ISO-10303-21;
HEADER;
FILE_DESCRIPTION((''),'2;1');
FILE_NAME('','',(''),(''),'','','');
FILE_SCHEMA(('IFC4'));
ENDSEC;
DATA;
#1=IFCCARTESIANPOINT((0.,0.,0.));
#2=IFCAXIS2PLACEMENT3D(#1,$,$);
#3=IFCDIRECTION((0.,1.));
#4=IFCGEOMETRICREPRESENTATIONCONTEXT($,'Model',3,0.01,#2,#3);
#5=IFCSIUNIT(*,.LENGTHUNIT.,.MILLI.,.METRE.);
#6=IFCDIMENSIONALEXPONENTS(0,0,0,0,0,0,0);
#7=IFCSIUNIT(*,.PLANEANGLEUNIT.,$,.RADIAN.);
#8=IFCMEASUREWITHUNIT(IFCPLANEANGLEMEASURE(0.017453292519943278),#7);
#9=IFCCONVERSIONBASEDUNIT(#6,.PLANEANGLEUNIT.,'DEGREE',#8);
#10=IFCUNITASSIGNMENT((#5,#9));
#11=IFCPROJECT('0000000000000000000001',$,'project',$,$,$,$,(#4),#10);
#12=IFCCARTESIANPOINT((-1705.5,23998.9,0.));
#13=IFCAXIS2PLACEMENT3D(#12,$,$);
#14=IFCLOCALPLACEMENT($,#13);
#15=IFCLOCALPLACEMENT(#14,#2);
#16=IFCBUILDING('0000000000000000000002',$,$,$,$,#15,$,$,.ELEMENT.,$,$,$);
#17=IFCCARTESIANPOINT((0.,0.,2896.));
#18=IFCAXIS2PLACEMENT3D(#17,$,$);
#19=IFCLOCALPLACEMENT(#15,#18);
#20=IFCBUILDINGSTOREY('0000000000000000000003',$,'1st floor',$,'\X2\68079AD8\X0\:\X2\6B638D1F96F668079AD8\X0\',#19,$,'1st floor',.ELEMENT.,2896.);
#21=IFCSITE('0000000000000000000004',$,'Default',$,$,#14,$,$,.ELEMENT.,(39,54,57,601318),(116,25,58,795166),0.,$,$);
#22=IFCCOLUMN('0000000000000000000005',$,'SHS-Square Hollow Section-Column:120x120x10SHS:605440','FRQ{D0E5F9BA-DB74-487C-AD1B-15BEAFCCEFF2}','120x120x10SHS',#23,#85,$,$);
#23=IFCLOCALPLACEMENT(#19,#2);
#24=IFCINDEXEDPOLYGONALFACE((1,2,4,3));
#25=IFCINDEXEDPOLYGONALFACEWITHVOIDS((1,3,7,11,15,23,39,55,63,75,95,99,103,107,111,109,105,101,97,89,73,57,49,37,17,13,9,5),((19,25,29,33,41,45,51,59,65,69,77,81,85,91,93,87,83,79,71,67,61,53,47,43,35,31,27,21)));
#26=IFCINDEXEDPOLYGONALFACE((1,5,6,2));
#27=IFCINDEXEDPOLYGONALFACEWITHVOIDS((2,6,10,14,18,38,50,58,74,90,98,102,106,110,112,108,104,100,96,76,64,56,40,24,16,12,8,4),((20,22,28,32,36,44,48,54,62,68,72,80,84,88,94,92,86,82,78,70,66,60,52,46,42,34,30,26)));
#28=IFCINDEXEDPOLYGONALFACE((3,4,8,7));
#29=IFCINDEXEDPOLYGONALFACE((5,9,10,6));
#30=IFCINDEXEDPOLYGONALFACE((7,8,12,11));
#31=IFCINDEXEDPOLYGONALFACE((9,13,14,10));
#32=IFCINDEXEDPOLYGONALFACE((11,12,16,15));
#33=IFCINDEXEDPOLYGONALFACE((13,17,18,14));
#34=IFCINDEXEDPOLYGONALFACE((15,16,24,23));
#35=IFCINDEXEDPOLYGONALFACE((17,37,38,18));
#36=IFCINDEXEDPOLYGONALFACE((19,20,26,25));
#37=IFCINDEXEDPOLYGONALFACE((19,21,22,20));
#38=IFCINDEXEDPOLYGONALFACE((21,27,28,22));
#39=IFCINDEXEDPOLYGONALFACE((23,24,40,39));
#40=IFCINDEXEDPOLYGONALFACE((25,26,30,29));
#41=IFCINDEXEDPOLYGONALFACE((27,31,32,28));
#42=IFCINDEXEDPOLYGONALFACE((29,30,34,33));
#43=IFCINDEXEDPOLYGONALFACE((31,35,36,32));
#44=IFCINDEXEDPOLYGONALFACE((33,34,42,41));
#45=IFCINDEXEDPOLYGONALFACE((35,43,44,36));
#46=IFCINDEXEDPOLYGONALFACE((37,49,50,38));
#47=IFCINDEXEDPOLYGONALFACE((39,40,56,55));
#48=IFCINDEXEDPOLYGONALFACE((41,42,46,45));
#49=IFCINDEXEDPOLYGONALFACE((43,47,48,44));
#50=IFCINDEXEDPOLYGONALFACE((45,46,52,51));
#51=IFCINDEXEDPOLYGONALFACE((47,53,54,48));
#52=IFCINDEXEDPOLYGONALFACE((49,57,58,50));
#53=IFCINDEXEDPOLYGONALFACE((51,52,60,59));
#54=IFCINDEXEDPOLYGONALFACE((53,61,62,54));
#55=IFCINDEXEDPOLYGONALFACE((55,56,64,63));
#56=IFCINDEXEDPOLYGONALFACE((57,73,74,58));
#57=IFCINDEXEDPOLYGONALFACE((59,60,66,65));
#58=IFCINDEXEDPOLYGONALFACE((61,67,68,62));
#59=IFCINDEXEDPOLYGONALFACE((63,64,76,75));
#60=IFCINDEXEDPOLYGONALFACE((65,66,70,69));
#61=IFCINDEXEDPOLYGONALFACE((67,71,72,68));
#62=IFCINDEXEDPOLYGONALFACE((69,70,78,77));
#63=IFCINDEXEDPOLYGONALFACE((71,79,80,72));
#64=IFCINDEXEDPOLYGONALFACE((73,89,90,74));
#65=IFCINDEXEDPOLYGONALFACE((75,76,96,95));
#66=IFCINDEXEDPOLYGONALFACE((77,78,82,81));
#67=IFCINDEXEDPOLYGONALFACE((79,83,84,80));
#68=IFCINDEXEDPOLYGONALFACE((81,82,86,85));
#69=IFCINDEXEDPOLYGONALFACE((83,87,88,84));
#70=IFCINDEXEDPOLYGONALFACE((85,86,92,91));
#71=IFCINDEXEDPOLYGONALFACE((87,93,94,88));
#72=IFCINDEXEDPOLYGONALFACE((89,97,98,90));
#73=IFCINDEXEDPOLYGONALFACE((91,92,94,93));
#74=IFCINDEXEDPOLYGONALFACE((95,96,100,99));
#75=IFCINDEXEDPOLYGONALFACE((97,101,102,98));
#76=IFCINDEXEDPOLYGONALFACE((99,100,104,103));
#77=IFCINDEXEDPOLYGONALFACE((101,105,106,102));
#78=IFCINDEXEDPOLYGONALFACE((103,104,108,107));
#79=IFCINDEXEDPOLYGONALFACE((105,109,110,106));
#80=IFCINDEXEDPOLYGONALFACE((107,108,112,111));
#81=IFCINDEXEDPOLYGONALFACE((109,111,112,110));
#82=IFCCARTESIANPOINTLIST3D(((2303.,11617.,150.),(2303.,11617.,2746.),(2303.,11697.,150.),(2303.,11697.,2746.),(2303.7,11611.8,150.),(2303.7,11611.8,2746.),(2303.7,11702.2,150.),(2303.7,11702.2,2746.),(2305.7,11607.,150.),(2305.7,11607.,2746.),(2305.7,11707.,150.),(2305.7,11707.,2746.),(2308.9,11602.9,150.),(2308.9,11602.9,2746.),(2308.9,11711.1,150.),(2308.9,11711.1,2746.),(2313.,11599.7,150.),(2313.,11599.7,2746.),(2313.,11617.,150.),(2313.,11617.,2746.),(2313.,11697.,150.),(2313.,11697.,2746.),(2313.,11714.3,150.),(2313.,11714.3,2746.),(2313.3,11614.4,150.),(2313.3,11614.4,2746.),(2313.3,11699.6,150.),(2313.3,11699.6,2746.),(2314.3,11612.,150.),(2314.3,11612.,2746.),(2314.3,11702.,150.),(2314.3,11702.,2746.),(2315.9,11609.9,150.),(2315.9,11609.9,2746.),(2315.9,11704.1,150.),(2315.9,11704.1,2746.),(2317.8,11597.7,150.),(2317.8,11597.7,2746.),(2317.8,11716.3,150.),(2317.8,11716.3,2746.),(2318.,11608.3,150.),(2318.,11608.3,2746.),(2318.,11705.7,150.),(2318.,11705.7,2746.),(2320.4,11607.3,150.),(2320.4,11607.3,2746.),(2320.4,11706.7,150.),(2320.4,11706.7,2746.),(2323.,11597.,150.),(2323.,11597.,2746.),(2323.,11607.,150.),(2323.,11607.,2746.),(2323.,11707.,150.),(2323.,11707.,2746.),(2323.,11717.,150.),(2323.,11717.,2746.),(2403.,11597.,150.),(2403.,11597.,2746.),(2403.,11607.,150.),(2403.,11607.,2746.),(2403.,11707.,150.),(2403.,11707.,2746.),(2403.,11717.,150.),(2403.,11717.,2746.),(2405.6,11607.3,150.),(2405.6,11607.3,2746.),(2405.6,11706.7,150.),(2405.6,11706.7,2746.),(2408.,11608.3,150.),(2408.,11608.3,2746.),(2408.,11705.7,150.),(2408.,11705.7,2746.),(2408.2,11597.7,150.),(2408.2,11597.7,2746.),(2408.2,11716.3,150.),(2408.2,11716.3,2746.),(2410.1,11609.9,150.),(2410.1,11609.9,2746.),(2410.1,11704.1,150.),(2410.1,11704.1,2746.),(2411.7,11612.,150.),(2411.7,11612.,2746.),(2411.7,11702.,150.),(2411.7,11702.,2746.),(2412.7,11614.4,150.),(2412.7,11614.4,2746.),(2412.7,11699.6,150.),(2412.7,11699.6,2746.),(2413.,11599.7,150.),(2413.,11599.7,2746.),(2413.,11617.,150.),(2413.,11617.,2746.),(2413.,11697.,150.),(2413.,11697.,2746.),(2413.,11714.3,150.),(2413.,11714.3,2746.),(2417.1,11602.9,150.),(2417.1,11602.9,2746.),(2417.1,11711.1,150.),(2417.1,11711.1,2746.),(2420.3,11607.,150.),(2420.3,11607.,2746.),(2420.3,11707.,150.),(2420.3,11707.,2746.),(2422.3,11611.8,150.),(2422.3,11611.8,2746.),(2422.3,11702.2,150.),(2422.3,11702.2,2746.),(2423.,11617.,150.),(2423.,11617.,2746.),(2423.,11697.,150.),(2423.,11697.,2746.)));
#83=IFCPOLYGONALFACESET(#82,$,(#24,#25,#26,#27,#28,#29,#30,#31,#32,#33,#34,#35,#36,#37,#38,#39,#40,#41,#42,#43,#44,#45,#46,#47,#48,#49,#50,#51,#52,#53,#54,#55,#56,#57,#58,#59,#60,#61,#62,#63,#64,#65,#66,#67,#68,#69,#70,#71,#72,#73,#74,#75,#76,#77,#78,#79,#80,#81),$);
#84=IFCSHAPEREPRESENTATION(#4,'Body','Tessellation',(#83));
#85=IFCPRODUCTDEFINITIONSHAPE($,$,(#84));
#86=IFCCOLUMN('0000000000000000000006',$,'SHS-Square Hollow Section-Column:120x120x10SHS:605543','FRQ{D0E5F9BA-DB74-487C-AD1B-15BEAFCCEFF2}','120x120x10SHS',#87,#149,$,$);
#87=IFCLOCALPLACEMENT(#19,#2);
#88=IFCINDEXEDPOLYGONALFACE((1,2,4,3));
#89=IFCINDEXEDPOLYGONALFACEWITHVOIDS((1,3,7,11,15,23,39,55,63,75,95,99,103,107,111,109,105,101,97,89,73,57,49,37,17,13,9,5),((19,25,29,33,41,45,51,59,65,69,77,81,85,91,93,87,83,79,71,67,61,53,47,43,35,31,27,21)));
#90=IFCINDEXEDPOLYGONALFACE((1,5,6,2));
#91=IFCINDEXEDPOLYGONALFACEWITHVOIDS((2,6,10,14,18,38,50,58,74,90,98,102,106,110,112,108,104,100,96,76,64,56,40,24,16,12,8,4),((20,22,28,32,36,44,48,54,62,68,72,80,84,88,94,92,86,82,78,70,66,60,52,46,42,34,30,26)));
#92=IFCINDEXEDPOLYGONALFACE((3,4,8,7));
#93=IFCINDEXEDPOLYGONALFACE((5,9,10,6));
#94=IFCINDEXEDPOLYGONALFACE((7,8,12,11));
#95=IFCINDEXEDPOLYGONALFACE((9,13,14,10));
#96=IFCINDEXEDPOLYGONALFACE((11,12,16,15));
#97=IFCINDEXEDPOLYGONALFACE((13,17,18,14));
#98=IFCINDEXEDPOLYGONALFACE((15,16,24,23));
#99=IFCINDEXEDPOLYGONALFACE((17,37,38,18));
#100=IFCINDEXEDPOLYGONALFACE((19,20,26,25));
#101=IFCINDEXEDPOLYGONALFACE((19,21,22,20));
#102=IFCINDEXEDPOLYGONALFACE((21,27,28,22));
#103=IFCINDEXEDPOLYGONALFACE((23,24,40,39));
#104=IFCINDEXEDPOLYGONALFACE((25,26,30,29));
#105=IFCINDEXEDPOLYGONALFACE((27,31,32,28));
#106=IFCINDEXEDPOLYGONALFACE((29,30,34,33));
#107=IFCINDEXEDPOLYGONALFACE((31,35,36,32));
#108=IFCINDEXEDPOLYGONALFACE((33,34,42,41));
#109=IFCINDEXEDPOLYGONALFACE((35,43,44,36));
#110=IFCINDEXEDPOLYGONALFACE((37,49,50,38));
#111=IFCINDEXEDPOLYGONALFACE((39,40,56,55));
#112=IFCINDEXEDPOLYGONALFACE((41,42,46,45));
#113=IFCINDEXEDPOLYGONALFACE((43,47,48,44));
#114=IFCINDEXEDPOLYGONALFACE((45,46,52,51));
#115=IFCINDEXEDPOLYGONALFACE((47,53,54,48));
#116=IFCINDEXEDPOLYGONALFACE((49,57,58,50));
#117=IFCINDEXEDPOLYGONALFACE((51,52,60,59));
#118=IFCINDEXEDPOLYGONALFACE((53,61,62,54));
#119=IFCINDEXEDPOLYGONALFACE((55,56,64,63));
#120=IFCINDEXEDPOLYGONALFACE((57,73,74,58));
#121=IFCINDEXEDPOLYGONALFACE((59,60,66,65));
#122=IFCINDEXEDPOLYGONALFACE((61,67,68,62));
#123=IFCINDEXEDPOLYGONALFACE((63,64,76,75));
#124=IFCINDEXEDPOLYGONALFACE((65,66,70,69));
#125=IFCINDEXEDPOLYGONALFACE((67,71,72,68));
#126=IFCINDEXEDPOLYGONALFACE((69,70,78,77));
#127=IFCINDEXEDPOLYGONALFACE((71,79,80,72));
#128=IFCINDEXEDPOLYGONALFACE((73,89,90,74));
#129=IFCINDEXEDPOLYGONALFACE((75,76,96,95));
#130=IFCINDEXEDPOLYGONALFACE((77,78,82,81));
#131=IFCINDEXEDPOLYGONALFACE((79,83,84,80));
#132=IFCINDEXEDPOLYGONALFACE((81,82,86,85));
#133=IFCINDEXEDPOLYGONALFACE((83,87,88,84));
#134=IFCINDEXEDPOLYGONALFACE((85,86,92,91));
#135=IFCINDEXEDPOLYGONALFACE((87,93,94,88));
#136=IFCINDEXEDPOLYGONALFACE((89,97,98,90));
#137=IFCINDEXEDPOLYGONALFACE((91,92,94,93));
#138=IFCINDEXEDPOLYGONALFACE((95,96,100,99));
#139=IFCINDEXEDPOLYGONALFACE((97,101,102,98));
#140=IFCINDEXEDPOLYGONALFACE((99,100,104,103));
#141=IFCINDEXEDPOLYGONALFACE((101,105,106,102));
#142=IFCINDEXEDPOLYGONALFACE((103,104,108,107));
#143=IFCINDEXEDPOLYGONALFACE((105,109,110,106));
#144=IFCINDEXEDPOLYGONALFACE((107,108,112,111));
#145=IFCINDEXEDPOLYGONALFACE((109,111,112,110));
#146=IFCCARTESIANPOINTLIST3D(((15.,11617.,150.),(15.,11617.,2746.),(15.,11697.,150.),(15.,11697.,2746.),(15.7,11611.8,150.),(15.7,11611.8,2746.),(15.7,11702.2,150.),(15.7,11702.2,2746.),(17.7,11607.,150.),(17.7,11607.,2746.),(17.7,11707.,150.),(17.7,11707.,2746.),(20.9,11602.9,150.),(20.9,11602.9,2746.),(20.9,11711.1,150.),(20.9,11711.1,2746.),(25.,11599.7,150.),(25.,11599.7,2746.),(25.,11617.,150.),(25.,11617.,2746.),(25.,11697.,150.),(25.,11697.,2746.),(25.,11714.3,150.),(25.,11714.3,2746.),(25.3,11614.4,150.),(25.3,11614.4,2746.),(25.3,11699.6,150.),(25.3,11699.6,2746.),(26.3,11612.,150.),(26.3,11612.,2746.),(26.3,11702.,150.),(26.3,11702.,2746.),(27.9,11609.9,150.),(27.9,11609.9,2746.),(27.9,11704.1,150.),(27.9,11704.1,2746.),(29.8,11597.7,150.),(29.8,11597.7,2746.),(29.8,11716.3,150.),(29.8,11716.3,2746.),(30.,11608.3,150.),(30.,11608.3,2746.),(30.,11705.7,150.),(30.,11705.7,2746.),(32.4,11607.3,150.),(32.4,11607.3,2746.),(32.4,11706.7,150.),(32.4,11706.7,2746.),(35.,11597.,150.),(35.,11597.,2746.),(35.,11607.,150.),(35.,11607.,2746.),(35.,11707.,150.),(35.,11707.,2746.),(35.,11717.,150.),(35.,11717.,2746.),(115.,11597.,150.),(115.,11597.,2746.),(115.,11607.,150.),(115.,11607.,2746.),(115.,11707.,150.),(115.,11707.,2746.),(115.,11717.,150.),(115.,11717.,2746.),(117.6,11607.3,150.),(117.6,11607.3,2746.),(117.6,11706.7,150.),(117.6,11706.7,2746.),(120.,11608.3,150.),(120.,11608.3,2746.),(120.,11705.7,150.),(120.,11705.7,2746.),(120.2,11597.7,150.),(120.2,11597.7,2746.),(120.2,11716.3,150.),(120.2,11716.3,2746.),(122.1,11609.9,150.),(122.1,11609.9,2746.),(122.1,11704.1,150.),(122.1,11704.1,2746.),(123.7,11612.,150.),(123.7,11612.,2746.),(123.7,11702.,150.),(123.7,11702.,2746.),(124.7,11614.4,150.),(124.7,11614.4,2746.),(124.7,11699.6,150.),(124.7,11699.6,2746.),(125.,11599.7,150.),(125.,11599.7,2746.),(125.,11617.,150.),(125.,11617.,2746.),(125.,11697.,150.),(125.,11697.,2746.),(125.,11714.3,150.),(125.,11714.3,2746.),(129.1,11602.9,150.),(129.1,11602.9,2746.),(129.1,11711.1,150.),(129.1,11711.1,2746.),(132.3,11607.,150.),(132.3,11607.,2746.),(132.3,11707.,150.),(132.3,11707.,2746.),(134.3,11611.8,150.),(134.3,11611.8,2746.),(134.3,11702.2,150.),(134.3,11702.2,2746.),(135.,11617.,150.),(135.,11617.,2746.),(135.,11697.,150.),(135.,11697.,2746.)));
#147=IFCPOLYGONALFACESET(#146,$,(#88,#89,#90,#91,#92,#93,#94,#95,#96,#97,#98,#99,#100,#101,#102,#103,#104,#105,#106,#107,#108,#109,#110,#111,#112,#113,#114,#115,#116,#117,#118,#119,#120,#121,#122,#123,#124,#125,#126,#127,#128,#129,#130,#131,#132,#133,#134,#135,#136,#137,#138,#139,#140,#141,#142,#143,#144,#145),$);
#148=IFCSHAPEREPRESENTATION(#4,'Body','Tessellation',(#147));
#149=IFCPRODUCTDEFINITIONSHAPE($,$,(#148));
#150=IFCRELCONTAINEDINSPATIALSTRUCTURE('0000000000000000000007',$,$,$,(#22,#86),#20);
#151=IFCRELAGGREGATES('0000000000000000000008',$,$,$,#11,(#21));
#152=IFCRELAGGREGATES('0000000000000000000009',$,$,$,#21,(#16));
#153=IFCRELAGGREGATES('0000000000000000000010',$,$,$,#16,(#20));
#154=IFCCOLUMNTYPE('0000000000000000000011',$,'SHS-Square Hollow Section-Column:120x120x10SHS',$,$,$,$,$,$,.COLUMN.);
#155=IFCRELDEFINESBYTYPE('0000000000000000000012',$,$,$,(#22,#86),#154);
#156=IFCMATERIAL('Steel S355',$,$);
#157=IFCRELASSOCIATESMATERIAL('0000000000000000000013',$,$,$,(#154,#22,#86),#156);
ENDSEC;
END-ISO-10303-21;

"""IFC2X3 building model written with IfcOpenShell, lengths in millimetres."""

from ifc_helpers import new_model, entity, si_unit, converted_unit, direction, frame, origin, origin_2d, place, context, project, spatial, hollow_rectangle, extrude, clip, halfspace, material, type_object, element, save


model = new_model("IFC2X3")

# Units and contexts
model_context = context("Model", 3, precision=0.01, world=origin(), true_north=direction((0.0, 1.0)))
ifc_project = project(units=[si_unit("LENGTHUNIT", "METRE", prefix="MILLI"), converted_unit("PLANEANGLEUNIT", "DEGREE", entity("IfcPlaneAngleMeasure", 0.017453292519943278), si_unit("PLANEANGLEUNIT", "RADIAN"), dimensions=[0, 0, 0, 0, 0, 0, 0])], contexts=[model_context])

# Site, building, storey
site_placement = place(None, frame((-1705.5, 23998.9, 0.0)))
site = spatial("IfcSite", under=ifc_project, at=site_placement, Name="Default", CompositionType="ELEMENT", RefLatitude=(39, 54, 57, 601318), RefLongitude=(116, 25, 58, 795166), RefElevation=0.0)
building_placement = place(site_placement, origin())
building = spatial("IfcBuilding", under=site, at=building_placement, CompositionType="ELEMENT")
storey_placement = place(building_placement, frame((0.0, 0.0, 2896.0)))
storey = spatial("IfcBuildingStorey", under=building, at=storey_placement, Name="1st floor", ObjectType="标高:正负零标高", LongName="1st floor", CompositionType="ELEMENT", Elevation=2896.0)

# Shared definitions
ifc_material_1 = material(Name="Steel S355")

# Columns
column_type_1 = type_object("IfcColumnType", Name="SHS-Square Hollow Section-Column:120x120x10SHS", PredefinedType="COLUMN", material=ifc_material_1)
column_1_placement = place(storey_placement, frame((2363.0, 11657.0, 2830.9), z_axis=(0.0, 0.0, 1.0), x_axis=(0.0, -1.0, 0.0)))
element("IfcColumn", 1, at=column_1_placement, inside=storey, type_object=column_type_1, material=ifc_material_1, Name="SHS-Square Hollow Section-Column:120x120x10SHS:605440", Description="FRQ{D0E5F9BA-DB74-487C-AD1B-15BEAFCCEFF2}", ObjectType="120x120x10SHS", context=model_context, shape_type="Clipping", body=[
    clip(clip(extrude(hollow_rectangle(XDim=120.0, YDim=120.0, WallThickness=10.0, InnerFilletRadius=10.0, OuterFilletRadius=20.0, at=origin_2d()), origin(), (0.0, 0.0, -1.0), 2765.7), halfspace(frame((11657.0, -2363.0, -84.9), z_axis=(0.0, 0.0, -1.0), x_axis=(0.0, -1.0, 0.0)), True)), halfspace(frame((11657.0, -2363.0, -2680.9), z_axis=(0.0, 0.0, 1.0), x_axis=(0.0, 1.0, 0.0)), True)),
])
column_2_placement = place(storey_placement, frame((75.0, 11657.0, 2830.9), z_axis=(0.0, 0.0, 1.0), x_axis=(0.0, -1.0, 0.0)))
element("IfcColumn", 2, at=column_2_placement, inside=storey, type_object=column_type_1, material=ifc_material_1, Name="SHS-Square Hollow Section-Column:120x120x10SHS:605543", Description="FRQ{D0E5F9BA-DB74-487C-AD1B-15BEAFCCEFF2}", ObjectType="120x120x10SHS", context=model_context, shape_type="Clipping", body=[
    clip(clip(extrude(hollow_rectangle(XDim=120.0, YDim=120.0, WallThickness=10.0, InnerFilletRadius=10.0, OuterFilletRadius=20.0, at=origin_2d()), origin(), (0.0, 0.0, -1.0), 2765.7), halfspace(frame((11657.0, -75.0, -84.9), z_axis=(0.0, 0.0, -1.0), x_axis=(0.0, -1.0, 0.0)), True)), halfspace(frame((11657.0, -75.0, -2680.9), z_axis=(0.0, 0.0, 1.0), x_axis=(0.0, 1.0, 0.0)), True)),
])

save(model, "model.ifc")
